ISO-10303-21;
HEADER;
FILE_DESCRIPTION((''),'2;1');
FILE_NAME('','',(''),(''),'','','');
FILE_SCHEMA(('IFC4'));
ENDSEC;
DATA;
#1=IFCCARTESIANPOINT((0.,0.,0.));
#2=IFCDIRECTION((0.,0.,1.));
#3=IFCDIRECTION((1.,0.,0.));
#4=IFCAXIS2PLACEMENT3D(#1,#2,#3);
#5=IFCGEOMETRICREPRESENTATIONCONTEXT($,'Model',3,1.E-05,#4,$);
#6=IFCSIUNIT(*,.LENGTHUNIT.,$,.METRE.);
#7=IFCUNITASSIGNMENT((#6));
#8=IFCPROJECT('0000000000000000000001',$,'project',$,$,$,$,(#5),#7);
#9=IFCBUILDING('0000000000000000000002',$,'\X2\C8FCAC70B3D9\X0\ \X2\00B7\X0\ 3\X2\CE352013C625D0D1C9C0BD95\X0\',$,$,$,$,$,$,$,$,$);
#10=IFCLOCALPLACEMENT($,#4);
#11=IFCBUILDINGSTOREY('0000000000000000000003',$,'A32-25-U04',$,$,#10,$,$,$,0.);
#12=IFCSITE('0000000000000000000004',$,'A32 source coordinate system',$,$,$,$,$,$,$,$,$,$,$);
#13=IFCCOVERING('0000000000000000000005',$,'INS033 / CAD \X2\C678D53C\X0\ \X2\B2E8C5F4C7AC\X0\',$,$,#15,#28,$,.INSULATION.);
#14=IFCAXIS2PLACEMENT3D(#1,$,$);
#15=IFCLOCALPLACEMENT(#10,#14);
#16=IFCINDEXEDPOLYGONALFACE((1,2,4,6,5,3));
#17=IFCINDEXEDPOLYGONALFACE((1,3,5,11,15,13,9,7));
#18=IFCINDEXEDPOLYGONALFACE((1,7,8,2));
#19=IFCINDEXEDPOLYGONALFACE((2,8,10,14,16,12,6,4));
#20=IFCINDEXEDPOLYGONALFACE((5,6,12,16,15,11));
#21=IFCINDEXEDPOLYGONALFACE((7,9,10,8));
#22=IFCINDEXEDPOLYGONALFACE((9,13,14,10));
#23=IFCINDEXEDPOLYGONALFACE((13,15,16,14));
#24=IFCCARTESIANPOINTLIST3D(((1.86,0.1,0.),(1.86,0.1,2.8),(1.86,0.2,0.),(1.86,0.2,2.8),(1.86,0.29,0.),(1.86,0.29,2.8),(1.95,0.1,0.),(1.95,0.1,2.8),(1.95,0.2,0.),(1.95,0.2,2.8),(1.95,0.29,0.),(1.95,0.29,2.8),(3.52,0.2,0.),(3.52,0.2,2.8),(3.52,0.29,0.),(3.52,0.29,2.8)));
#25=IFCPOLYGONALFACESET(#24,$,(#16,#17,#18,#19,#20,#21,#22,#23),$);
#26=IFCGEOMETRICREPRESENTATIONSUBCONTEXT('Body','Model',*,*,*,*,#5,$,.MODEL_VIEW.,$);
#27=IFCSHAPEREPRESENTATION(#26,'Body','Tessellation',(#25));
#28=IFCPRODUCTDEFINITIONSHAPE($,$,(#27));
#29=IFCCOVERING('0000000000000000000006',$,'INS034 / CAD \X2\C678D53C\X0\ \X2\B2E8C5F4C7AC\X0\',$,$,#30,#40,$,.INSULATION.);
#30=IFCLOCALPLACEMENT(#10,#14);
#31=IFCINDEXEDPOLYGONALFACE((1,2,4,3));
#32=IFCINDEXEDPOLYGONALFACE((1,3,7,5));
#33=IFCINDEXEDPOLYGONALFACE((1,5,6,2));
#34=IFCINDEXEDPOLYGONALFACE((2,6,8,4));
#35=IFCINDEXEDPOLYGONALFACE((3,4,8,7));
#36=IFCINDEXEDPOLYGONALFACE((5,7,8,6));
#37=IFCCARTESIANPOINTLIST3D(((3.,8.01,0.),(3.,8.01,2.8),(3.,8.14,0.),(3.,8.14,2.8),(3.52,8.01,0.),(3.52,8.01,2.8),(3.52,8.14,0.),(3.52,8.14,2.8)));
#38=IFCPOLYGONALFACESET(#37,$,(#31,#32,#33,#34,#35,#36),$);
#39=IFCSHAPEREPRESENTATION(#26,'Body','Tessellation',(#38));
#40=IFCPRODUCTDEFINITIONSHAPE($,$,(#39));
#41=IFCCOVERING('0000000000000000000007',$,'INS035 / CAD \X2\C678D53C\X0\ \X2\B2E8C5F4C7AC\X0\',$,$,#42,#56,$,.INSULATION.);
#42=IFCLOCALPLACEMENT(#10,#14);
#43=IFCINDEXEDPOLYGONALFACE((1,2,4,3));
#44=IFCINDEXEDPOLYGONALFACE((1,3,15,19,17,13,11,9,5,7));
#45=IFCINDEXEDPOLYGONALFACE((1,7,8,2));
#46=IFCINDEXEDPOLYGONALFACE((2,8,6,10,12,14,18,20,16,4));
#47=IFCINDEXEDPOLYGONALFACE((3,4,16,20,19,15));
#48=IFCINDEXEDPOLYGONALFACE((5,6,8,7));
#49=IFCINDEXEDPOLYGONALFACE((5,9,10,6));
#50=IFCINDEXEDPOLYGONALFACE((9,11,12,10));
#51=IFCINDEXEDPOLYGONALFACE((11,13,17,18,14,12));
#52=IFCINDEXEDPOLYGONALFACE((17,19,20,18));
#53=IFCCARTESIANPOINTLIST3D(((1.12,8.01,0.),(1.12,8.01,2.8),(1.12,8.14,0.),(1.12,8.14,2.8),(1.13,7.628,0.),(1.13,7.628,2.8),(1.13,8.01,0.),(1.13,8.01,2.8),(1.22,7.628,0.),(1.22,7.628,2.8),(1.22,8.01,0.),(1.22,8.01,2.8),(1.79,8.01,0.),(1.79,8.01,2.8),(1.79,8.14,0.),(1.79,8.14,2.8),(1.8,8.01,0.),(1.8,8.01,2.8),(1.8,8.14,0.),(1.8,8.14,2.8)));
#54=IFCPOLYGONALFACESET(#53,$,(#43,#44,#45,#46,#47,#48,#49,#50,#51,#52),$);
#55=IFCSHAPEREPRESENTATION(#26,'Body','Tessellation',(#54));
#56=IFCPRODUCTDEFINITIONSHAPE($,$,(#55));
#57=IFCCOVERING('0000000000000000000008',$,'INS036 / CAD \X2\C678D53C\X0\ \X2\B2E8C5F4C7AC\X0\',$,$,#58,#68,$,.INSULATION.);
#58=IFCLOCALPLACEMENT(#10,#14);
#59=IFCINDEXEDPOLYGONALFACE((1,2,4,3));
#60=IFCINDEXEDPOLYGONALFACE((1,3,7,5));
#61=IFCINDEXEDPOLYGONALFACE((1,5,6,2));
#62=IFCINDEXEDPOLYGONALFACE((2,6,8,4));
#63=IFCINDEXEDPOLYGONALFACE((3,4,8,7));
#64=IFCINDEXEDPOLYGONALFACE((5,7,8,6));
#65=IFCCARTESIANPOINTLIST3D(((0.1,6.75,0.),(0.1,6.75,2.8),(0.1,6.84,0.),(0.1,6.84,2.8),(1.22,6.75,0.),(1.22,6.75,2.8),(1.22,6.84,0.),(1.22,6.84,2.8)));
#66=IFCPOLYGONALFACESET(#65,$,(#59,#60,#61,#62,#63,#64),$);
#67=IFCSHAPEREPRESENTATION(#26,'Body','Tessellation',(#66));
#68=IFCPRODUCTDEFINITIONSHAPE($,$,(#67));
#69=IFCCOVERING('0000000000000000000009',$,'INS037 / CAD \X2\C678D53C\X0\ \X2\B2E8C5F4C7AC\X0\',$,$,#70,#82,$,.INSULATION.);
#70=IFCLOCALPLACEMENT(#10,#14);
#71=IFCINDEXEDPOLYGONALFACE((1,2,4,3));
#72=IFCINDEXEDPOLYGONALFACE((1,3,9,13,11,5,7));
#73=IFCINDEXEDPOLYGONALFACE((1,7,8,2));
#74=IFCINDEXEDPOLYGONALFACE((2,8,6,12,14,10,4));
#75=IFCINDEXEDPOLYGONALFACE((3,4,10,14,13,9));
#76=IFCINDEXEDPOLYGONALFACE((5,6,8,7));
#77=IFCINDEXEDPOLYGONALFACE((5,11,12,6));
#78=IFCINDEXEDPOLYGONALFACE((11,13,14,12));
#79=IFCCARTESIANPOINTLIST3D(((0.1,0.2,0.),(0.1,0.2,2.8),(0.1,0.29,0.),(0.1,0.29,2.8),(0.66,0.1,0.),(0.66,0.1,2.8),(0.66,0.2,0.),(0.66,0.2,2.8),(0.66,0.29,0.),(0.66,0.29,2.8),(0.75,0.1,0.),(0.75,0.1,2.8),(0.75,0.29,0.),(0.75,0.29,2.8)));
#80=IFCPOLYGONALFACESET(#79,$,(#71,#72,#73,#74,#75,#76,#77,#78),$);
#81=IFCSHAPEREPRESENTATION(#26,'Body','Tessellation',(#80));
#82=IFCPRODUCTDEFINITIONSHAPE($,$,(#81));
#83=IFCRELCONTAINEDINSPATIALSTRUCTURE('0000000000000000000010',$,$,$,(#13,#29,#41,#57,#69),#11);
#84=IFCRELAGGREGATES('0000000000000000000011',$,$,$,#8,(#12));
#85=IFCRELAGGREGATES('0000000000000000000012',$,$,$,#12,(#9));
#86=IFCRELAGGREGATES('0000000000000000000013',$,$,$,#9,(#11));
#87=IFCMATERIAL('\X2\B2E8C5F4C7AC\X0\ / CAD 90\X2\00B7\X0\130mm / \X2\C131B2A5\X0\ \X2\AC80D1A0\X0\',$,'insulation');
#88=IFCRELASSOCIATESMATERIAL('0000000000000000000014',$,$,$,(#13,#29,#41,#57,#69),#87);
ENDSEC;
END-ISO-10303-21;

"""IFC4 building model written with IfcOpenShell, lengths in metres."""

from ifc_helpers import new_model, si_unit, origin, origin_with_axes, place, context, subcontext, project, spatial, polyline, outline, extrude, material, element, save


model = new_model("IFC4")

# Units and contexts
model_context = context("Model", 3, precision=1e-05, world=origin_with_axes())
body_context = subcontext(model_context, "Body", "Model", "MODEL_VIEW")
ifc_project = project(units=[si_unit("LENGTHUNIT", "METRE")], contexts=[model_context])

# Site, building, storey
storey_placement = place(None, origin_with_axes())
site = spatial("IfcSite", under=ifc_project, Name="A32 source coordinate system")
building = spatial("IfcBuilding", under=site, Name="주거동 · 3층–옥탑지붕")
storey = spatial("IfcBuildingStorey", under=building, at=storey_placement, Name="A32-25-U04", Elevation=0.0)

# Coverings
ifc_material = material(Name="단열재 / CAD 90·130mm / 성능 검토", Category="insulation")
covering_1_placement = place(storey_placement, origin_with_axes())
element("IfcCovering", 1, at=covering_1_placement, inside=storey, material=ifc_material, Name="INS033 / CAD 외피 단열재", PredefinedType="INSULATION", context=body_context, shape_type="SweptSolid", body=[
    extrude(outline(polyline([(1.95, 0.29), (3.52, 0.29), (3.52, 0.2), (1.95, 0.2), (1.95, 0.1), (1.86, 0.1), (1.86, 0.2), (1.86, 0.29), (1.95, 0.29)])), origin(), (0.0, 0.0, 1.0), 2.8),
])
covering_2_placement = place(storey_placement, origin_with_axes())
element("IfcCovering", 2, at=covering_2_placement, inside=storey, material=ifc_material, Name="INS034 / CAD 외피 단열재", PredefinedType="INSULATION", context=body_context, shape_type="SweptSolid", body=[
    extrude(outline(polyline([(3.52, 8.01), (3.0, 8.01), (3.0, 8.14), (3.52, 8.14), (3.52, 8.01)])), origin(), (0.0, 0.0, 1.0), 2.8),
])
covering_3_placement = place(storey_placement, origin_with_axes())
element("IfcCovering", 3, at=covering_3_placement, inside=storey, material=ifc_material, Name="INS035 / CAD 외피 단열재", PredefinedType="INSULATION", context=body_context, shape_type="SweptSolid", body=[
    extrude(outline(polyline([(1.8, 8.01), (1.79, 8.01), (1.22, 8.01), (1.22, 7.628), (1.13, 7.628), (1.13, 8.01), (1.12, 8.01), (1.12, 8.14), (1.79, 8.14), (1.8, 8.14), (1.8, 8.01)])), origin(), (0.0, 0.0, 1.0), 2.8),
])
covering_4_placement = place(storey_placement, origin_with_axes())
element("IfcCovering", 4, at=covering_4_placement, inside=storey, material=ifc_material, Name="INS036 / CAD 외피 단열재", PredefinedType="INSULATION", context=body_context, shape_type="SweptSolid", body=[
    extrude(outline(polyline([(1.22, 6.84), (1.22, 6.75), (0.1, 6.75), (0.1, 6.84), (1.22, 6.84)])), origin(), (0.0, 0.0, 1.0), 2.8),
])
covering_5_placement = place(storey_placement, origin_with_axes())
element("IfcCovering", 5, at=covering_5_placement, inside=storey, material=ifc_material, Name="INS037 / CAD 외피 단열재", PredefinedType="INSULATION", context=body_context, shape_type="SweptSolid", body=[
    extrude(outline(polyline([(0.1, 0.2), (0.1, 0.29), (0.66, 0.29), (0.75, 0.29), (0.75, 0.1), (0.66, 0.1), (0.66, 0.2), (0.1, 0.2)])), origin(), (0.0, 0.0, 1.0), 2.8),
])

save(model, "model.ifc")
